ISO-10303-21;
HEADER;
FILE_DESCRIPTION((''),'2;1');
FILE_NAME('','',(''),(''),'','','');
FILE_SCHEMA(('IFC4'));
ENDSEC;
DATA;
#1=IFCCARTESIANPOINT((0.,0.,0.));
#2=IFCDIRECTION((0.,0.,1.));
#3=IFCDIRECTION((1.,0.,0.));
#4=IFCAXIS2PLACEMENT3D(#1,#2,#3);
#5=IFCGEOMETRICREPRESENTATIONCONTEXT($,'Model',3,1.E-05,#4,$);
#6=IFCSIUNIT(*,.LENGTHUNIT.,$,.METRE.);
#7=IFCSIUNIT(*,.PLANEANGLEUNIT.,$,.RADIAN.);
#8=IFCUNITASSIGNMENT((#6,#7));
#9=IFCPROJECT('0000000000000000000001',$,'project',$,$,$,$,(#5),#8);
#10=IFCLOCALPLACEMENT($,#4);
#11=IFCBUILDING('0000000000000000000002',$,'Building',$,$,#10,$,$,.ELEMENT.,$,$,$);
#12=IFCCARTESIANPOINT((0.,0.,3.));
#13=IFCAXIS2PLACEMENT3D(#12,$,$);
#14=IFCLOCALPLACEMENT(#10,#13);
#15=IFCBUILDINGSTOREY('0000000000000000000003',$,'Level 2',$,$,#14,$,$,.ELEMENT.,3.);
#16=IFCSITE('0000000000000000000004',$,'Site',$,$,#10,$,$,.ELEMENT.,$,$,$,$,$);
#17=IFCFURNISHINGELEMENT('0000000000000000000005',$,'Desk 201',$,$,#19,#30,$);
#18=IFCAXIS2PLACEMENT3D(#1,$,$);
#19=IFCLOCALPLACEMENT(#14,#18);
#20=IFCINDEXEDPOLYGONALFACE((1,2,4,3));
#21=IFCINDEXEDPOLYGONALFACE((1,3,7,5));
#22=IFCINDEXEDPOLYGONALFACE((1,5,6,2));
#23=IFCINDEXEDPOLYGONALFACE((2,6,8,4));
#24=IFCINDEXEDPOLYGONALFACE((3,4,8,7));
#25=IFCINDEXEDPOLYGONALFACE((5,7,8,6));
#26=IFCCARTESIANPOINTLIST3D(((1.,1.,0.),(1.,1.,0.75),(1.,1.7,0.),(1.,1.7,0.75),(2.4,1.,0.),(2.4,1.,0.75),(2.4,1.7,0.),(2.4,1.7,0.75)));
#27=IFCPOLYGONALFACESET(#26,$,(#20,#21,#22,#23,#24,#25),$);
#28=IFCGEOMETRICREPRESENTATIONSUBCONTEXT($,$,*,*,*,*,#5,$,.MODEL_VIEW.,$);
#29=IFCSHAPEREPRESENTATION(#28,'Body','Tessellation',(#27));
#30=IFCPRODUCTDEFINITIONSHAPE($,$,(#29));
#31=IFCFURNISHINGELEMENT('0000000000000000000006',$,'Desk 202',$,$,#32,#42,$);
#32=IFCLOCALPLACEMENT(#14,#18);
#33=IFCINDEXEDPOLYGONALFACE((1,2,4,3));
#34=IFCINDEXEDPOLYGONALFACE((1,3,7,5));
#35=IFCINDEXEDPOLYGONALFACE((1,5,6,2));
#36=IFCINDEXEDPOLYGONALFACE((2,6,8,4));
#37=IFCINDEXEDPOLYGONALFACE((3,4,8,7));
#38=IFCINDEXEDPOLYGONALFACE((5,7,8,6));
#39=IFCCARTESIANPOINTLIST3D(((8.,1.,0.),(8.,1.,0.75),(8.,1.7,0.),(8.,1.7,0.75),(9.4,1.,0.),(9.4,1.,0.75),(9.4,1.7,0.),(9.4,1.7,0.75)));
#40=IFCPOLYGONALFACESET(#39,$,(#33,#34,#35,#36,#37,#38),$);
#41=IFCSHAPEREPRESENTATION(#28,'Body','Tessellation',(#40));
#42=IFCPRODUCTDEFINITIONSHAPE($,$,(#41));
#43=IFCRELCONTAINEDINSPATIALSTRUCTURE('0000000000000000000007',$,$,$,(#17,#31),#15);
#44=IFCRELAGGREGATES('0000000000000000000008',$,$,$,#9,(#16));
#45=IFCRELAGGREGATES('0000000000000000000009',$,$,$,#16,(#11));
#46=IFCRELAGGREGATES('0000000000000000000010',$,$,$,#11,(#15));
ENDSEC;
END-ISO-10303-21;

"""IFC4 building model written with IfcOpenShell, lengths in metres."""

from ifc_helpers import new_model, si_unit, frame, frame_2d, origin, origin_with_axes, place, context, subcontext, project, spatial, rectangle, extrude, element, save


model = new_model("IFC4")

# Units and contexts
model_context = context("Model", 3, precision=1e-05, world=origin_with_axes())
sub_context = subcontext(model_context, None, None, "MODEL_VIEW")
ifc_project = project(units=[si_unit("LENGTHUNIT", "METRE"), si_unit("PLANEANGLEUNIT", "RADIAN")], contexts=[model_context])

# Site, building, storey
placement = place(None, origin_with_axes())
site = spatial("IfcSite", under=ifc_project, at=placement, Name="Site", CompositionType="ELEMENT")
building = spatial("IfcBuilding", under=site, at=placement, Name="Building", CompositionType="ELEMENT")
storey_placement = place(placement, frame((0.0, 0.0, 3.0)))
storey = spatial("IfcBuildingStorey", under=building, at=storey_placement, Name="Level 2", CompositionType="ELEMENT", Elevation=3.0)

# Furnishing elements
for number, where, name in (
    (1, (1.0, 1.0, 3.0), "Desk 201"),
    (2, (8.0, 1.0, 3.0), "Desk 202"),
):
    element("IfcFurnishingElement", number, at=place(placement, frame(where)), inside=storey, Name=name, context=sub_context, shape_type="SweptSolid", body=[
        extrude(rectangle(XDim=1.4, YDim=0.7, at=frame_2d((0.7, 0.35))), origin(), (0.0, 0.0, 1.0), 0.75),
    ])

save(model, "model.ifc")
